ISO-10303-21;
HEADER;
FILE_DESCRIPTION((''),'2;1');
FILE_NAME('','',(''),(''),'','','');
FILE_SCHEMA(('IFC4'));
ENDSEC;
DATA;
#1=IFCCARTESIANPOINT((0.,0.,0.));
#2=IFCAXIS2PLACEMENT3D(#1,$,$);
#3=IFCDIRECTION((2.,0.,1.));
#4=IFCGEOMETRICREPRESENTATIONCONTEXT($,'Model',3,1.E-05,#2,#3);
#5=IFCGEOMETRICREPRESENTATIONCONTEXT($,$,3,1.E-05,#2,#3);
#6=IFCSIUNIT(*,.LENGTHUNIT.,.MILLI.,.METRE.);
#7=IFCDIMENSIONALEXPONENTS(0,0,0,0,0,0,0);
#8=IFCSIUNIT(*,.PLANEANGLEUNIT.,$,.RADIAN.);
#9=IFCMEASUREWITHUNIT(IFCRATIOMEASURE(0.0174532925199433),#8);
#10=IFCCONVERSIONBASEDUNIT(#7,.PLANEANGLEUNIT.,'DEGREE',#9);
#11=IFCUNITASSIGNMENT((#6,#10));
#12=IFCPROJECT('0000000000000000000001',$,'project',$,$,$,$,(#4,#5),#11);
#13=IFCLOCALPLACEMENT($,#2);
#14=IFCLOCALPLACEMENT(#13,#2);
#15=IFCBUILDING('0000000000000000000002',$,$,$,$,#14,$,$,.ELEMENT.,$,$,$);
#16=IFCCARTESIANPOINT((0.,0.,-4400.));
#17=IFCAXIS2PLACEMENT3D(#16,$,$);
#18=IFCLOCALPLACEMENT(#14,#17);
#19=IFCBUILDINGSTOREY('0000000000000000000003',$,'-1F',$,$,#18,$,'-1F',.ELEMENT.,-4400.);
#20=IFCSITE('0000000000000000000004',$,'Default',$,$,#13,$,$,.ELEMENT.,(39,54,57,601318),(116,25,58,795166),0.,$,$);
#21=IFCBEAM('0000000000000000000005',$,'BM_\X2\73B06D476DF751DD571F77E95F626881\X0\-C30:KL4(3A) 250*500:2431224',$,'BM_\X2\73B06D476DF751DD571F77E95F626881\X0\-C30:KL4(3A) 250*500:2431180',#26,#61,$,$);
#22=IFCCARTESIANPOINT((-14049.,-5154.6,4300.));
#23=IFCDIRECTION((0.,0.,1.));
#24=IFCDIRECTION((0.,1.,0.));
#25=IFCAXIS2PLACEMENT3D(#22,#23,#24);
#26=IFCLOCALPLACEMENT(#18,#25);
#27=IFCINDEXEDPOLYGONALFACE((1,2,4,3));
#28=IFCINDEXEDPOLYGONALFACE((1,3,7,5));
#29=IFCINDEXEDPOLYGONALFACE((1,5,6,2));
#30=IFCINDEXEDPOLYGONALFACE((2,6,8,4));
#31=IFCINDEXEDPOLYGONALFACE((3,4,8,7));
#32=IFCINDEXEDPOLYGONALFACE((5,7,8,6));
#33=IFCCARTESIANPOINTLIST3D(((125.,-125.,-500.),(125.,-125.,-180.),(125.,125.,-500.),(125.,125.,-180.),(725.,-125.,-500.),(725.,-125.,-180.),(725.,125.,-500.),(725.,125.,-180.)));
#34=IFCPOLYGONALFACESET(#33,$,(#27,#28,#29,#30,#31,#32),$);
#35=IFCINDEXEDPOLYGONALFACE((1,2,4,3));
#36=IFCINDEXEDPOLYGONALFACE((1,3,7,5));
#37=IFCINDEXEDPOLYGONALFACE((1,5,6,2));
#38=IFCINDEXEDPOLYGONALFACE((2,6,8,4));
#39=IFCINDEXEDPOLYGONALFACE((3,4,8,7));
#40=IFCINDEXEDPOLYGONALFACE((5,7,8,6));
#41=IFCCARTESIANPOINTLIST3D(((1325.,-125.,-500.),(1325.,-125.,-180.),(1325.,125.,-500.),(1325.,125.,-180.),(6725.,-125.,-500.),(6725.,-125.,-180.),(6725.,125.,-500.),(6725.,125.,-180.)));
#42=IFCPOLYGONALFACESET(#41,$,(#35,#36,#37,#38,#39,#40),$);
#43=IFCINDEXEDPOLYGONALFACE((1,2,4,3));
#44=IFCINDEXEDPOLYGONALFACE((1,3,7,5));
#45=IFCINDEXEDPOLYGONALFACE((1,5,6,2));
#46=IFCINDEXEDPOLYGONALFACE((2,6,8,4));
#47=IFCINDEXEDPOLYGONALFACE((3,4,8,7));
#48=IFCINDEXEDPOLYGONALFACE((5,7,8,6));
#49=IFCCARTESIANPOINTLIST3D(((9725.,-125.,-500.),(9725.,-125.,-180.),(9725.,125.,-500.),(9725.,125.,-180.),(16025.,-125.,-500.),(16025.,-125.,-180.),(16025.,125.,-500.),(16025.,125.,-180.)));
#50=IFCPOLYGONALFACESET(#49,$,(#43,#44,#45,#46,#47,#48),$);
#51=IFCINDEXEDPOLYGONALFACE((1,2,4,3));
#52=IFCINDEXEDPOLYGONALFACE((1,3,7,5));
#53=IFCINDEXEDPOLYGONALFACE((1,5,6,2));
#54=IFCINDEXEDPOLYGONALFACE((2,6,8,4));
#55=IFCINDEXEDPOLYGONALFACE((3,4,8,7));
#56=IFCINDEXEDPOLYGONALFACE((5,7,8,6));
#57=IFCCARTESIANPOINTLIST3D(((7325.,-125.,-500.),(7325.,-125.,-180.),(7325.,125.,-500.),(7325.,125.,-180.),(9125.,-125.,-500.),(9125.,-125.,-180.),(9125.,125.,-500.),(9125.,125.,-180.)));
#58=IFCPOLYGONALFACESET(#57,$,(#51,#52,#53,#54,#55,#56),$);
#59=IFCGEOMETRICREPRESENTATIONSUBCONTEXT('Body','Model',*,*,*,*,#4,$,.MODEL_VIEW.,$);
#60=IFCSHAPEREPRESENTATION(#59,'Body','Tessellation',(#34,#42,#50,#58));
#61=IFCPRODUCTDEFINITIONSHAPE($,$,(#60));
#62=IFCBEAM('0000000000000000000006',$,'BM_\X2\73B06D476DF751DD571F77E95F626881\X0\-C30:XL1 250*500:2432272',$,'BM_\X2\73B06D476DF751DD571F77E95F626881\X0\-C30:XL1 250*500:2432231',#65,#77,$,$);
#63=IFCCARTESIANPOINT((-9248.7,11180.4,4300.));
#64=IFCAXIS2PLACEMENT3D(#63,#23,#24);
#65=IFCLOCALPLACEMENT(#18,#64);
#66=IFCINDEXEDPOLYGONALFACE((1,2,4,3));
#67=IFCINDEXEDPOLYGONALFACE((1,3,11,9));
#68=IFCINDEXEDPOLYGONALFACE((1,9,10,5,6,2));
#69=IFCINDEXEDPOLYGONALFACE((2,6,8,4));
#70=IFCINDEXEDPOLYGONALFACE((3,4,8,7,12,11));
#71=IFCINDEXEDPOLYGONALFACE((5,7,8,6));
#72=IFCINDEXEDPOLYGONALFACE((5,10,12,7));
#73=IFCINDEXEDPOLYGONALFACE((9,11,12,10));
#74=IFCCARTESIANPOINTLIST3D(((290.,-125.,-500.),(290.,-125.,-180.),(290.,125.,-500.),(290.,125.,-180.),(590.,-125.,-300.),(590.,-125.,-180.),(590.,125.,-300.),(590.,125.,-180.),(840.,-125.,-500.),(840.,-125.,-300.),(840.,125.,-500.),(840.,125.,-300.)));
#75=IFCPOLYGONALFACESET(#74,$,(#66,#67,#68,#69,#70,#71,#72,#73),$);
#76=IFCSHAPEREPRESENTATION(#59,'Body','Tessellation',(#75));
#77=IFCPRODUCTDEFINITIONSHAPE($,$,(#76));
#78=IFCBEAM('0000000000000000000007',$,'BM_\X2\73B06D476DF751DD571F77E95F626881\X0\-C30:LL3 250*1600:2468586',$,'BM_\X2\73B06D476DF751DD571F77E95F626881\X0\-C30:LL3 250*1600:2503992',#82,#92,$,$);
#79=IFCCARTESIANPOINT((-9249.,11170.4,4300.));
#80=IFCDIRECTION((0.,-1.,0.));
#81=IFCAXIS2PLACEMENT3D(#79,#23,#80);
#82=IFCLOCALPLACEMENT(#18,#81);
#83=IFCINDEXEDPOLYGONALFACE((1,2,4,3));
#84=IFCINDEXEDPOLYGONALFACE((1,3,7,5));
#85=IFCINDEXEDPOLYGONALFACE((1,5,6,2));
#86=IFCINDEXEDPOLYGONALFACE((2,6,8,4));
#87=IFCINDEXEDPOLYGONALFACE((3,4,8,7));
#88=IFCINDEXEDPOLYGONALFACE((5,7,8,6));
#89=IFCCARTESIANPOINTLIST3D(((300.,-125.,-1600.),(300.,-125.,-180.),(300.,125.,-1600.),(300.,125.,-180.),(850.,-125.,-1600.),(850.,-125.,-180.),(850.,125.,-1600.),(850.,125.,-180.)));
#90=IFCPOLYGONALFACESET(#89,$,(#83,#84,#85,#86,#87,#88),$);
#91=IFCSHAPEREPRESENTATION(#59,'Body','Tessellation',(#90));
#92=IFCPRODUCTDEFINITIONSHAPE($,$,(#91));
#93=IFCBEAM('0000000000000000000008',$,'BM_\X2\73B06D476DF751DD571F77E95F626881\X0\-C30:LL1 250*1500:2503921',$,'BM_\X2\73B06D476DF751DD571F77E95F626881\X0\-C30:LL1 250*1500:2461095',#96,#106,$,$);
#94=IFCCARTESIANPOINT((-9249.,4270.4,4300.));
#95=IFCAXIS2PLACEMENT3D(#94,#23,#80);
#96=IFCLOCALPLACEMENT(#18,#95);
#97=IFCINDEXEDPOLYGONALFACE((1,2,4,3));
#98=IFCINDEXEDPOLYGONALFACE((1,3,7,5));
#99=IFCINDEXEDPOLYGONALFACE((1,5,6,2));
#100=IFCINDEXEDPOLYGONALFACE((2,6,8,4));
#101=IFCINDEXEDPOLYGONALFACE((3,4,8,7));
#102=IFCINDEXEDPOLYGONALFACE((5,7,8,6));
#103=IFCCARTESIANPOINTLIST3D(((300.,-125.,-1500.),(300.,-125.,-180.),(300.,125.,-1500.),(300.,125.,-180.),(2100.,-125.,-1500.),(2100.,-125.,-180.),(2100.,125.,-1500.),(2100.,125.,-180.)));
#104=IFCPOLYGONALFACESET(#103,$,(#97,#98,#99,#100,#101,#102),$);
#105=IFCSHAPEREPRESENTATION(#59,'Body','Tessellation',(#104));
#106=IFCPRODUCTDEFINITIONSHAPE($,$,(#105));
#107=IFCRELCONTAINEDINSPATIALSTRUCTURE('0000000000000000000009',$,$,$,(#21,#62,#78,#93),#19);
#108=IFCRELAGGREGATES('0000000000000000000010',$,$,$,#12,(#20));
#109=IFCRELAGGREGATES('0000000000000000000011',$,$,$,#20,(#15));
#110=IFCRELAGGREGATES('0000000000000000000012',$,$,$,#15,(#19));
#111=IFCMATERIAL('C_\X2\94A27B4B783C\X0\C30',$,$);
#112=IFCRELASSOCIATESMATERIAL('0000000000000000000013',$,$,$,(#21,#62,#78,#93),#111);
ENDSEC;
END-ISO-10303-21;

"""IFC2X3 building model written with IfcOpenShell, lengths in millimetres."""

from ifc_helpers import new_model, entity, si_unit, converted_unit, direction, frame, frame_2d, origin, origin_2d_with_axis, place, context, subcontext, project, spatial, polyline, rectangle, extrude, clip, bounded_halfspace, material, element, save


model = new_model("IFC2X3")

# Units and contexts
model_context = context("Model", 3, precision=1e-05, world=origin(), true_north=direction((2.0, 0.0, 1.0)))
context_of_model = context(None, 3, precision=1e-05, world=origin(), true_north=direction((2.0, 0.0, 1.0)))
body_context = subcontext(model_context, "Body", "Model", "MODEL_VIEW")
ifc_project = project(units=[si_unit("LENGTHUNIT", "METRE", prefix="MILLI"), converted_unit("PLANEANGLEUNIT", "DEGREE", entity("IfcRatioMeasure", 0.0174532925199433), si_unit("PLANEANGLEUNIT", "RADIAN"), dimensions=[0, 0, 0, 0, 0, 0, 0])], contexts=[model_context, context_of_model])

# Site, building, storey
site_placement = place(None, origin())
site = spatial("IfcSite", under=ifc_project, at=site_placement, Name="Default", CompositionType="ELEMENT", RefLatitude=(39, 54, 57, 601318), RefLongitude=(116, 25, 58, 795166), RefElevation=0.0)
building_placement = place(site_placement, origin())
building = spatial("IfcBuilding", under=site, at=building_placement, CompositionType="ELEMENT")
storey_placement = place(building_placement, frame((0.0, 0.0, -4400.0)))
storey = spatial("IfcBuildingStorey", under=building, at=storey_placement, Name="-1F", LongName="-1F", CompositionType="ELEMENT", Elevation=-4400.0)

# Beams
ifc_material_1 = material(Name="C_钢筋砼C30")
beam_1_placement = place(storey_placement, frame((-14049.0, -5154.6, 4300.0), z_axis=(0.0, 0.0, 1.0), x_axis=(0.0, 1.0, 0.0)))
element("IfcBeam", 1, at=beam_1_placement, inside=storey, material=ifc_material_1, Name="BM_现浇混凝土矩形梁-C30:KL4(3A) 250*500:2431224", ObjectType="BM_现浇混凝土矩形梁-C30:KL4(3A) 250*500:2431180", context=body_context, shape_type="SweptSolid", body=[
    extrude(rectangle(XDim=320.0, YDim=250.0, at=frame_2d((0.0, 0.0), x_axis=(1.0, 0.0))), frame((125.0, 0.0, -340.0), z_axis=(1.0, 0.0, 0.0), x_axis=(0.0, 0.0, 1.0)), (0.0, 0.0, 1.0), 600.0),
    extrude(rectangle(XDim=320.0, YDim=250.0, at=origin_2d_with_axis()), frame((1325.0, 0.0, -340.0), z_axis=(1.0, 0.0, 0.0), x_axis=(0.0, 0.0, 1.0)), (0.0, 0.0, 1.0), 5400.0),
    extrude(rectangle(XDim=320.0, YDim=250.0, at=origin_2d_with_axis()), frame((9725.0, 0.0, -340.0), z_axis=(1.0, 0.0, 0.0), x_axis=(0.0, 0.0, 1.0)), (0.0, 0.0, 1.0), 6300.0),
    extrude(rectangle(XDim=320.0, YDim=250.0, at=frame_2d((0.0, 0.0), x_axis=(1.0, 0.0))), frame((7325.0, 0.0, -340.0), z_axis=(1.0, 0.0, 0.0), x_axis=(0.0, 0.0, 1.0)), (0.0, 0.0, 1.0), 1800.0),
])
beam_2_placement = place(storey_placement, frame((-9248.7, 11180.4, 4300.0), z_axis=(0.0, 0.0, 1.0), x_axis=(0.0, 1.0, 0.0)))
element("IfcBeam", 2, at=beam_2_placement, inside=storey, material=ifc_material_1, Name="BM_现浇混凝土矩形梁-C30:XL1 250*500:2432272", ObjectType="BM_现浇混凝土矩形梁-C30:XL1 250*500:2432231", context=body_context, shape_type="Clipping", body=[
    clip(extrude(rectangle(XDim=320.0, YDim=250.0, at=frame_2d((0.0, 0.0), x_axis=(0.0, 1.0))), frame((290.0, 0.0, -340.0), z_axis=(1.0, 0.0, 0.0), x_axis=(0.0, 1.0, 0.0)), (0.0, 0.0, 1.0), 550.0), bounded_halfspace(frame((590.0, 9462.7, -300.0), z_axis=(1.0, 0.0, 0.0), x_axis=(0.0, 0.0, 1.0)), False, frame((290.0, 0.0, -340.0), z_axis=(1.0, 0.0, 0.0), x_axis=(0.0, 1.0, 0.0)), polyline([(-125.0, 40.0), (125.0, 40.0), (125.0, 160.0), (-125.0, 160.0), (-125.0, 40.0)]))),
])
beam_3_placement = place(storey_placement, frame((-9249.0, 11170.4, 4300.0), z_axis=(0.0, 0.0, 1.0), x_axis=(0.0, -1.0, 0.0)))
element("IfcBeam", 3, at=beam_3_placement, inside=storey, material=ifc_material_1, Name="BM_现浇混凝土矩形梁-C30:LL3 250*1600:2468586", ObjectType="BM_现浇混凝土矩形梁-C30:LL3 250*1600:2503992", context=body_context, shape_type="SweptSolid", body=[
    extrude(rectangle(XDim=1420.0, YDim=250.0, at=frame_2d((0.0, 0.0), x_axis=(1.0, 0.0))), frame((300.0, 0.0, -890.0), z_axis=(1.0, 0.0, 0.0), x_axis=(0.0, 0.0, -1.0)), (0.0, 0.0, 1.0), 550.0),
])
beam_4_placement = place(storey_placement, frame((-9249.0, 4270.4, 4300.0), z_axis=(0.0, 0.0, 1.0), x_axis=(0.0, -1.0, 0.0)))
element("IfcBeam", 4, at=beam_4_placement, inside=storey, material=ifc_material_1, Name="BM_现浇混凝土矩形梁-C30:LL1 250*1500:2503921", ObjectType="BM_现浇混凝土矩形梁-C30:LL1 250*1500:2461095", context=body_context, shape_type="SweptSolid", body=[
    extrude(rectangle(XDim=1320.0, YDim=250.0, at=frame_2d((0.0, 0.0), x_axis=(1.0, 0.0))), frame((300.0, 0.0, -840.0), z_axis=(1.0, 0.0, 0.0), x_axis=(0.0, 0.0, -1.0)), (0.0, 0.0, 1.0), 1800.0),
])

save(model, "model.ifc")
